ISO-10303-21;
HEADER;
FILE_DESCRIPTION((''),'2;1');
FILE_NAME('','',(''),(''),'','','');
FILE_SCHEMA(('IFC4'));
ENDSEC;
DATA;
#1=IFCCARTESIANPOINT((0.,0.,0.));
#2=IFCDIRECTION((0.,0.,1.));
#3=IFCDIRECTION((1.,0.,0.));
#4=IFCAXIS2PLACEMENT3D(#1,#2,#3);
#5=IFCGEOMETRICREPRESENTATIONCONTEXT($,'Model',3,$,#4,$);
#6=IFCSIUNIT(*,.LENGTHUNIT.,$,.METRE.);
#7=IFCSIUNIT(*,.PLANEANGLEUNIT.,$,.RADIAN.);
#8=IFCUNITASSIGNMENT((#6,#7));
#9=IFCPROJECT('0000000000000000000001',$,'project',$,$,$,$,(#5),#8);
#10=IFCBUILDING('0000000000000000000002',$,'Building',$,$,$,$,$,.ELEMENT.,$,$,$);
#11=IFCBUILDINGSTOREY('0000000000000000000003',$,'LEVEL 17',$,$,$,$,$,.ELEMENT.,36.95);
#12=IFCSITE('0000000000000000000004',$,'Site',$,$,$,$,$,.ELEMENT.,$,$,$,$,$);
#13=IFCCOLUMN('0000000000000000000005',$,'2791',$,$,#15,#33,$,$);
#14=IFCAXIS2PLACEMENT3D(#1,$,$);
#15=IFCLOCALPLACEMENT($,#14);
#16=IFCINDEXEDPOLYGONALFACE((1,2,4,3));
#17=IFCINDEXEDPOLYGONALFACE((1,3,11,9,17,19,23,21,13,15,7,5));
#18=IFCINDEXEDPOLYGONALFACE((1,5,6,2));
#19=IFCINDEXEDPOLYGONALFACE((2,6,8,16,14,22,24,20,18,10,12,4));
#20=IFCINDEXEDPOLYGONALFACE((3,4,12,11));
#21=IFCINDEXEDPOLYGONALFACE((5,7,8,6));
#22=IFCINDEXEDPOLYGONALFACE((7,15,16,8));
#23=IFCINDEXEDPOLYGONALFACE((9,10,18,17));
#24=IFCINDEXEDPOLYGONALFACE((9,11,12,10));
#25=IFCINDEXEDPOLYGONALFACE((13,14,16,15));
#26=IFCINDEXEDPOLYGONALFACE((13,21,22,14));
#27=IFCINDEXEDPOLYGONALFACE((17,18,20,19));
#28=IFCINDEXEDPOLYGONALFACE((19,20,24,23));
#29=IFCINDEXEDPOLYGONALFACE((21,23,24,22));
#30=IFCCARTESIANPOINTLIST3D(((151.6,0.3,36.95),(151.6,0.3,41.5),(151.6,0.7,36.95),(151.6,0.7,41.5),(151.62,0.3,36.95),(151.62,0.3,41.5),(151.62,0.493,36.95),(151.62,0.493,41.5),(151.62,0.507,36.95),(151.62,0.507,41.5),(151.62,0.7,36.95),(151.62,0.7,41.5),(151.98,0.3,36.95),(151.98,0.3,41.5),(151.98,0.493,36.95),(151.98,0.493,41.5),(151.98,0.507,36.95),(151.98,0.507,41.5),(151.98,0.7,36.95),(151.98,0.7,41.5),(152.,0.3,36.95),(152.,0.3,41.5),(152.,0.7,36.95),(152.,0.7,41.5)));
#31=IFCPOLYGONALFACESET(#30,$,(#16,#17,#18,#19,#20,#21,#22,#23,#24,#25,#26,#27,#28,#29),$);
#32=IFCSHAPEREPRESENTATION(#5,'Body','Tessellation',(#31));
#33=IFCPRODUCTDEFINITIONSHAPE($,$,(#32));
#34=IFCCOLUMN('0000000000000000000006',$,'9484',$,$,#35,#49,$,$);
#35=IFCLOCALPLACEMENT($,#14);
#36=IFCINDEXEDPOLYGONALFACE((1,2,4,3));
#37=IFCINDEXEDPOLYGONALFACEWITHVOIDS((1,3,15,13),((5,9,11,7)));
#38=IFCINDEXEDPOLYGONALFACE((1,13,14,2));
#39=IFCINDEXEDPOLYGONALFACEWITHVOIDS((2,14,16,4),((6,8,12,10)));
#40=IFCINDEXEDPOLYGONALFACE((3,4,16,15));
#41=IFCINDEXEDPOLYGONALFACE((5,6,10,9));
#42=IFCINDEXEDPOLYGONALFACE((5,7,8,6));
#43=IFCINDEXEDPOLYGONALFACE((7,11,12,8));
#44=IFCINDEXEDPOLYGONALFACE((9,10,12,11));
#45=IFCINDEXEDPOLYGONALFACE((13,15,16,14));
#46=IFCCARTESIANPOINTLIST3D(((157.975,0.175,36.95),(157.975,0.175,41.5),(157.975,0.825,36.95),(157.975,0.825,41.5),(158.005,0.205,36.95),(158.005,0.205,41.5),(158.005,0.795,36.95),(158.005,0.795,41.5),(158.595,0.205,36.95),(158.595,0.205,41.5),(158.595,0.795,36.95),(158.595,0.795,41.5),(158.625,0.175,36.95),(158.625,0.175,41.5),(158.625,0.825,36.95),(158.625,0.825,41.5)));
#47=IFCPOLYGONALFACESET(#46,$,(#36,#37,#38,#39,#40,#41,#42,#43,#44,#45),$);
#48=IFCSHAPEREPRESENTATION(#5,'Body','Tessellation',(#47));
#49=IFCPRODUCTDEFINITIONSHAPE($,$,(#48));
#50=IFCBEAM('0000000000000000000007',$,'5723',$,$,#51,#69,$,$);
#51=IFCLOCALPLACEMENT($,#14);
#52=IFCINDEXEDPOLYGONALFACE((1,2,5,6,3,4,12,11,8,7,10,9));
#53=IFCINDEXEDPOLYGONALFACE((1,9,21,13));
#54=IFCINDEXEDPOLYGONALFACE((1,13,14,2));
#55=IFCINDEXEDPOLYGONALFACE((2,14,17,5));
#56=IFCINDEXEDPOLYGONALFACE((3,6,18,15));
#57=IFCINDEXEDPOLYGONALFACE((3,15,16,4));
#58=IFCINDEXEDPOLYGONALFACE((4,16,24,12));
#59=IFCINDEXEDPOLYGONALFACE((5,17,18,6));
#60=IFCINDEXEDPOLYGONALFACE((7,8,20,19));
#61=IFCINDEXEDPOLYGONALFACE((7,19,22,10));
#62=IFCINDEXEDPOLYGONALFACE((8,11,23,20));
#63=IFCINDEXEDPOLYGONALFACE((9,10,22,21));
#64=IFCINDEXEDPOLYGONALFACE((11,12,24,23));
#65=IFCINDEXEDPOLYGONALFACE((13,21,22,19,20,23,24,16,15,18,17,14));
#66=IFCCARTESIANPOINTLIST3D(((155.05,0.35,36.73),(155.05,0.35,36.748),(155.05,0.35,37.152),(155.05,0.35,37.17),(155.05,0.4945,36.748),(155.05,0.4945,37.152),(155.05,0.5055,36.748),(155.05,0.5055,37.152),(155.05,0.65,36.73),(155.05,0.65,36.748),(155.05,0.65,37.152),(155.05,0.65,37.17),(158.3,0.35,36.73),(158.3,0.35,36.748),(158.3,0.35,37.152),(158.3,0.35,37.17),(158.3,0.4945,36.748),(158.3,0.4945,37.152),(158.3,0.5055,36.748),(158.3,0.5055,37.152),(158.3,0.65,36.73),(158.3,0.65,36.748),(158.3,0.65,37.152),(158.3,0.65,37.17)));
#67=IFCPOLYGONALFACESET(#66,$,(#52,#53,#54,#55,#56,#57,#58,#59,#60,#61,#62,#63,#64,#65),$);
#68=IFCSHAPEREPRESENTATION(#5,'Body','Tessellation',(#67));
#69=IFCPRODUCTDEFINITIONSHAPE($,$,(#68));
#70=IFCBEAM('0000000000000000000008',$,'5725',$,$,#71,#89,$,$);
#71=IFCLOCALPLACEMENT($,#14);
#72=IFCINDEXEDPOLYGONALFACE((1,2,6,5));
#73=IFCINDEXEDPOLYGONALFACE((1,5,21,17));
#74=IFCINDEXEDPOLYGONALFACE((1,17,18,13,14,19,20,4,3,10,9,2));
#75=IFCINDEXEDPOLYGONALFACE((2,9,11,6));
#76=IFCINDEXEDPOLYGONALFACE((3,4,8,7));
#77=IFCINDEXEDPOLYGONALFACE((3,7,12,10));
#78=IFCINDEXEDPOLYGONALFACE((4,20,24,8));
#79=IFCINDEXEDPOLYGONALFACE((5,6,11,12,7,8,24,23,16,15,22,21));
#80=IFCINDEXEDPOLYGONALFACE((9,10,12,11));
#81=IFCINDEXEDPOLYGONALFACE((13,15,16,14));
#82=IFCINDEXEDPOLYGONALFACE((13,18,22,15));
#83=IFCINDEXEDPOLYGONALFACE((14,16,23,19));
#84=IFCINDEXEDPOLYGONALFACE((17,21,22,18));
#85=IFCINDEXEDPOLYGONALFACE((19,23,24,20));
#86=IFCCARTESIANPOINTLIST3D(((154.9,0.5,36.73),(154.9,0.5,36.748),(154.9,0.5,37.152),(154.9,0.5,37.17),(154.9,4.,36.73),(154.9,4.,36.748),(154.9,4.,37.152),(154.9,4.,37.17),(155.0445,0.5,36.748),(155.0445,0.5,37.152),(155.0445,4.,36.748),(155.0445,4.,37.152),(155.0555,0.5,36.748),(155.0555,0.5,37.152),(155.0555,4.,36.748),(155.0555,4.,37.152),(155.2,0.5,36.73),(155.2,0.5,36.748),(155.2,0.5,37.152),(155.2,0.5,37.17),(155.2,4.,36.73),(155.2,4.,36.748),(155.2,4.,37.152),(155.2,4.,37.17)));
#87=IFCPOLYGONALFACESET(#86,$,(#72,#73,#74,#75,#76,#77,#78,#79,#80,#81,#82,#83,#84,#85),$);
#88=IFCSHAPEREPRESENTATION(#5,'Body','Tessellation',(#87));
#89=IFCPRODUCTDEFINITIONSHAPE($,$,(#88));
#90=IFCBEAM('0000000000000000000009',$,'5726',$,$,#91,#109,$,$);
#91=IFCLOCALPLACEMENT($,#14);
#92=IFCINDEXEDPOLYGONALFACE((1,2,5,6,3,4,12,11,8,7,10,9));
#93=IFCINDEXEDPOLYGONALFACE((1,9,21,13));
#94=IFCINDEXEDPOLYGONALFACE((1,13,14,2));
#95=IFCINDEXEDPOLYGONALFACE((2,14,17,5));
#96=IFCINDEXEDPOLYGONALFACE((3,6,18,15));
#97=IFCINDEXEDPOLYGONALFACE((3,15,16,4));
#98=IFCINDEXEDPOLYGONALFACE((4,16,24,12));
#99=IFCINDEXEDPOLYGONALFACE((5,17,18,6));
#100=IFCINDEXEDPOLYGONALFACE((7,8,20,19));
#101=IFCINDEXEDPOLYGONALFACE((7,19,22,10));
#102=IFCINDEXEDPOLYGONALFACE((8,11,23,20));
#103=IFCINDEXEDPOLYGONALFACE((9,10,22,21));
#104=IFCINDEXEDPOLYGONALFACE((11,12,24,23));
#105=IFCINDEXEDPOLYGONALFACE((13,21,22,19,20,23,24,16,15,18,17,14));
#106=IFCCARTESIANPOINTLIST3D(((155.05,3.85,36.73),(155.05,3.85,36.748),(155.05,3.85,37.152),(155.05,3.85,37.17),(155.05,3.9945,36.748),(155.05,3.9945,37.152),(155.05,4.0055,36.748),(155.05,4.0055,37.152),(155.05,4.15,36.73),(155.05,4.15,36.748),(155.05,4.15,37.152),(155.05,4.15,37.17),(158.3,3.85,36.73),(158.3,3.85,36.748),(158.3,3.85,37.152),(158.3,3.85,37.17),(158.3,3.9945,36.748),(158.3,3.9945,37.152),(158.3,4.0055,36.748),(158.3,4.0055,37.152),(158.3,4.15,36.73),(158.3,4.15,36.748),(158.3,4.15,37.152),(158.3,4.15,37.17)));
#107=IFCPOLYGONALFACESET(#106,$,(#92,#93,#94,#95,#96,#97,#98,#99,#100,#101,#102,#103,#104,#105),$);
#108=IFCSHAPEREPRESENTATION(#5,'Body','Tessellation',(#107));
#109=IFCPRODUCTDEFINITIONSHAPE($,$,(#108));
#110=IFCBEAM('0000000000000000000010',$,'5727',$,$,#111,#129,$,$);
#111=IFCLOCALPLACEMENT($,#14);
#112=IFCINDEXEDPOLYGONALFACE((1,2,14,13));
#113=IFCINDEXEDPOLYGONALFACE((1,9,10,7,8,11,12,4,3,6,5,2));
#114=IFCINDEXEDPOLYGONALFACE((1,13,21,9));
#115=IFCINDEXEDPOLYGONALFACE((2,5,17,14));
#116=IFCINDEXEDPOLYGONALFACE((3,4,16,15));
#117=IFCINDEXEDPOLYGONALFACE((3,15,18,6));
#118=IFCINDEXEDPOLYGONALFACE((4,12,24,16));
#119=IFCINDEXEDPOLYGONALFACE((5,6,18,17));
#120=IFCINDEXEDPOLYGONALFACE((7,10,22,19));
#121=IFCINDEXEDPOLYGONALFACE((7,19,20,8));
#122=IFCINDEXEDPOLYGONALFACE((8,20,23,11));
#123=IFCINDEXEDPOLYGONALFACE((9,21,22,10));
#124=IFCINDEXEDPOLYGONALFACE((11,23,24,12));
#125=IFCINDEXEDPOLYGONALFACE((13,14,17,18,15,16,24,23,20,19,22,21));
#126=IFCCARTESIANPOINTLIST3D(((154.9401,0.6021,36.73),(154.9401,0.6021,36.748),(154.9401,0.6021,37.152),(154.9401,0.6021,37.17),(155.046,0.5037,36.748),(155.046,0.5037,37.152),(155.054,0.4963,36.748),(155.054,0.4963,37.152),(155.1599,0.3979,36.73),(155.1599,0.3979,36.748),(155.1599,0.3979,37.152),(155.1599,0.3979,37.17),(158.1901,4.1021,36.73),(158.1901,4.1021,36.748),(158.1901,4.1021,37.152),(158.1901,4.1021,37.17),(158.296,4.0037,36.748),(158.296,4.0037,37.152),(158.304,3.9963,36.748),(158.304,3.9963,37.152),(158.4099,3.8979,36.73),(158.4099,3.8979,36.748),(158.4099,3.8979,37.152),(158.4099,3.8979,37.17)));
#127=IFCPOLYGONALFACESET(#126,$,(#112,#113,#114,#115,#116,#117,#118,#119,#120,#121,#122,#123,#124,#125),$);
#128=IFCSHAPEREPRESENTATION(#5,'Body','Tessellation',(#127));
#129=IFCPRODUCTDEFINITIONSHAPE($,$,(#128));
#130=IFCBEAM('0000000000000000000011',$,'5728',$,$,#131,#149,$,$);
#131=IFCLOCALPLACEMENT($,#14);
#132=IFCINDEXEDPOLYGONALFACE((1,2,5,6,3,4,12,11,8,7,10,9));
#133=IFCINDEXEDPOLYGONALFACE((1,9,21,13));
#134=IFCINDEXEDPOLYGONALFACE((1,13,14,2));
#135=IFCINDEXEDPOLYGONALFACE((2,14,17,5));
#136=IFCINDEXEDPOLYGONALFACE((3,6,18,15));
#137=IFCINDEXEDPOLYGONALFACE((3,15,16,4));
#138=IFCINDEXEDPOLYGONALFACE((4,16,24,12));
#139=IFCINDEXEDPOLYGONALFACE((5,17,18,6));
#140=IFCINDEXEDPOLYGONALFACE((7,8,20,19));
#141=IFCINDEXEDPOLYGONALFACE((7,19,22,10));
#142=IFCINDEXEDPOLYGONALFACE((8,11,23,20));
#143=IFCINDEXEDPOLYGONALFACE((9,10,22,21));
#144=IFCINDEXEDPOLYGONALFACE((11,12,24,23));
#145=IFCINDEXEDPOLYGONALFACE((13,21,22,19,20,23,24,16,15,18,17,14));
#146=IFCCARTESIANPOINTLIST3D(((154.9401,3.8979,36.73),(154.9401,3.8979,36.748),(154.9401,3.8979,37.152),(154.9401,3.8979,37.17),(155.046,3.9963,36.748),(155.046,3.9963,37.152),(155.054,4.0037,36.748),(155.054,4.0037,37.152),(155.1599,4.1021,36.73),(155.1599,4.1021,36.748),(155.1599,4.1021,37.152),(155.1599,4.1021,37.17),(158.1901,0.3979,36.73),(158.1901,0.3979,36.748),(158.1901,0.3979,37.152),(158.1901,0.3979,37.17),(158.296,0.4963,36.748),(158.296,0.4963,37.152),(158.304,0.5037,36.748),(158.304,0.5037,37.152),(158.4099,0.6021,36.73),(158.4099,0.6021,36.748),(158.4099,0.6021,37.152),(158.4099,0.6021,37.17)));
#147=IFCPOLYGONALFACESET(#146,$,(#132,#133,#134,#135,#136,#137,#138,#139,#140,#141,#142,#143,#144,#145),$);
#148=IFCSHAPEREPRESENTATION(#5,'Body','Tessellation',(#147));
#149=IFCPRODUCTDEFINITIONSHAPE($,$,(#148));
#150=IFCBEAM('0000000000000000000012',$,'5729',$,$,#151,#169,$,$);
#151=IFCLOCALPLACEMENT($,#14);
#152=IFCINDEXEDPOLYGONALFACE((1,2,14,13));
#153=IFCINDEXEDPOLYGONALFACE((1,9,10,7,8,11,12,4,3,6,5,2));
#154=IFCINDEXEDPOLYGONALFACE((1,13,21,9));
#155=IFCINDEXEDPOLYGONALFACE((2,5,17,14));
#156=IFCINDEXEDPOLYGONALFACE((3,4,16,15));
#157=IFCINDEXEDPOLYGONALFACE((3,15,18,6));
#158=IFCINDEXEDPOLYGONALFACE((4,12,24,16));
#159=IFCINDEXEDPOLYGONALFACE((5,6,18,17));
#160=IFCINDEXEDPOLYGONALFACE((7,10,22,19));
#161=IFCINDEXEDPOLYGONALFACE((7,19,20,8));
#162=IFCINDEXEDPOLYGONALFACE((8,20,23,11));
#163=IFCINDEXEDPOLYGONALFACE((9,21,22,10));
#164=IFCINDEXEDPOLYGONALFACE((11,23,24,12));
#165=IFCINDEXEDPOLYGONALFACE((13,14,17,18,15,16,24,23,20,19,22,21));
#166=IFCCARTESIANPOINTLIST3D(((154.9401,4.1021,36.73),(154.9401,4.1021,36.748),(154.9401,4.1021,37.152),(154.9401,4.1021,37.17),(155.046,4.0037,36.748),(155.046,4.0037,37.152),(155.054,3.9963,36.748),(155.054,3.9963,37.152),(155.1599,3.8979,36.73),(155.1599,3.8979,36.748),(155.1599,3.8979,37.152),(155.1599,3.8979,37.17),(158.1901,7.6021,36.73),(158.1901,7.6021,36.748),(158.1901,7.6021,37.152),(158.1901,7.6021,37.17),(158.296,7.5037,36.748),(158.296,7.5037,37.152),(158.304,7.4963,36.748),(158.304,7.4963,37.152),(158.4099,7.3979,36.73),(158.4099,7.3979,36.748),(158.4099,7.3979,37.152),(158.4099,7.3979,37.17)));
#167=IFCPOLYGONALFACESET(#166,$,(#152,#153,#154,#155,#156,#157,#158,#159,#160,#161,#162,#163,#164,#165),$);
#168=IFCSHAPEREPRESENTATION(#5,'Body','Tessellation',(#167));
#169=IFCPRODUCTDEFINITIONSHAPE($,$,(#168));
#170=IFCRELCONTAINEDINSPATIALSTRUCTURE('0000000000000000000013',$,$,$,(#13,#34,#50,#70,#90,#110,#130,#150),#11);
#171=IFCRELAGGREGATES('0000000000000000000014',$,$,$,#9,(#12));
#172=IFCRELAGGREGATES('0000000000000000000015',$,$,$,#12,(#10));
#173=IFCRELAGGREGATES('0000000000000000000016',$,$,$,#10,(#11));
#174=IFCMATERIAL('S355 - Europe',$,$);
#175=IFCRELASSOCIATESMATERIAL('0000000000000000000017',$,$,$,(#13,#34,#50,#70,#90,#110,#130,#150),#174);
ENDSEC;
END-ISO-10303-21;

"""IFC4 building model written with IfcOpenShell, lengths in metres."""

from ifc_helpers import new_model, si_unit, frame, origin_with_axes, origin_2d_with_axis, place, context, project, spatial, hollow_rectangle, i_section, extrude, material, material_profile, profile_set, profile_usage, element, save


model = new_model("IFC4")

# Units and contexts
model_context = context("Model", 3, world=origin_with_axes())
ifc_project = project(units=[si_unit("LENGTHUNIT", "METRE"), si_unit("PLANEANGLEUNIT", "RADIAN")], contexts=[model_context])

# Site, building, storey
site = spatial("IfcSite", under=ifc_project, Name="Site", CompositionType="ELEMENT")
building = spatial("IfcBuilding", under=site, Name="Building", CompositionType="ELEMENT")
storey = spatial("IfcBuildingStorey", under=building, Name="LEVEL 17", CompositionType="ELEMENT", Elevation=36.95)

# Columns
ifc_material = material(Name="S355 - Europe")
ifc_material_profile_1 = material_profile(ifc_material, i_section(OverallWidth=0.4, OverallDepth=0.4, WebThickness=0.014, FlangeThickness=0.02, at=origin_2d_with_axis()))
ifc_profile_set_1 = profile_set([ifc_material_profile_1])
ifc_profile_usage_1 = profile_usage(ifc_profile_set_1, cardinal=10)
column_1_placement = place(None, frame((151.8, 0.5, 36.95), z_axis=(0.0, 0.0, 1.0), x_axis=(0.0, -1.0, 0.0)))
element("IfcColumn", 1, at=column_1_placement, inside=storey, material=ifc_profile_usage_1, Name="2791", context=model_context, shape_type="SweptSolid", body=[
    extrude(i_section(OverallWidth=0.4, OverallDepth=0.4, WebThickness=0.014, FlangeThickness=0.02, at=origin_2d_with_axis()), origin_with_axes(), (0.0, 0.0, 1.0), 4.55),
])
ifc_material_profile_2 = material_profile(ifc_material, hollow_rectangle(XDim=0.65, YDim=0.65, WallThickness=0.03, at=origin_2d_with_axis()))
ifc_profile_set_2 = profile_set([ifc_material_profile_2])
ifc_profile_usage_2 = profile_usage(ifc_profile_set_2, cardinal=10)
column_2_placement = place(None, frame((158.3, 0.5, 36.95), z_axis=(0.0, 0.0, 1.0), x_axis=(0.0, -1.0, 0.0)))
element("IfcColumn", 2, at=column_2_placement, inside=storey, material=ifc_profile_usage_2, Name="9484", context=model_context, shape_type="SweptSolid", body=[
    extrude(hollow_rectangle(XDim=0.65, YDim=0.65, WallThickness=0.03, at=origin_2d_with_axis()), origin_with_axes(), (0.0, 0.0, 1.0), 4.55),
])

# Beams
ifc_material_profile_3 = material_profile(ifc_material, i_section(OverallWidth=0.3, OverallDepth=0.44, WebThickness=0.011, FlangeThickness=0.018, at=origin_2d_with_axis()))
ifc_profile_set_3 = profile_set([ifc_material_profile_3])
ifc_profile_usage_3 = profile_usage(ifc_profile_set_3, cardinal=10)
beam_1_placement = place(None, frame((155.05, 0.5, 36.95), z_axis=(1.0, 0.0, 0.0), x_axis=(0.0, 1.0, 0.0)))
element("IfcBeam", 3, at=beam_1_placement, inside=storey, material=ifc_profile_usage_3, Name="5723", context=model_context, shape_type="SweptSolid", body=[
    extrude(i_section(OverallWidth=0.3, OverallDepth=0.44, WebThickness=0.011, FlangeThickness=0.018, at=origin_2d_with_axis()), origin_with_axes(), (0.0, 0.0, 1.0), 3.25),
])
ifc_material_profile_4 = material_profile(ifc_material, i_section(OverallWidth=0.3, OverallDepth=0.44, WebThickness=0.011, FlangeThickness=0.018, at=origin_2d_with_axis()))
ifc_profile_set_4 = profile_set([ifc_material_profile_4])
ifc_profile_usage_4 = profile_usage(ifc_profile_set_4, cardinal=10)
beam_2_placement = place(None, frame((155.05, 4.0, 36.95), z_axis=(0.0, -1.0, 0.0), x_axis=(1.0, 0.0, 0.0)))
element("IfcBeam", 4, at=beam_2_placement, inside=storey, material=ifc_profile_usage_4, Name="5725", context=model_context, shape_type="SweptSolid", body=[
    extrude(i_section(OverallWidth=0.3, OverallDepth=0.44, WebThickness=0.011, FlangeThickness=0.018, at=origin_2d_with_axis()), origin_with_axes(), (0.0, 0.0, 1.0), 3.5),
])
ifc_material_profile_5 = material_profile(ifc_material, i_section(OverallWidth=0.3, OverallDepth=0.44, WebThickness=0.011, FlangeThickness=0.018, at=origin_2d_with_axis()))
ifc_profile_set_5 = profile_set([ifc_material_profile_5])
ifc_profile_usage_5 = profile_usage(ifc_profile_set_5, cardinal=10)
beam_3_placement = place(None, frame((155.05, 4.0, 36.95), z_axis=(1.0, 0.0, 0.0), x_axis=(0.0, 1.0, 0.0)))
element("IfcBeam", 5, at=beam_3_placement, inside=storey, material=ifc_profile_usage_5, Name="5726", context=model_context, shape_type="SweptSolid", body=[
    extrude(i_section(OverallWidth=0.3, OverallDepth=0.44, WebThickness=0.011, FlangeThickness=0.018, at=origin_2d_with_axis()), origin_with_axes(), (0.0, 0.0, 1.0), 3.25),
])
ifc_material_profile_6 = material_profile(ifc_material, i_section(OverallWidth=0.3, OverallDepth=0.44, WebThickness=0.011, FlangeThickness=0.018, at=origin_2d_with_axis()))
ifc_profile_set_6 = profile_set([ifc_material_profile_6])
ifc_profile_usage_6 = profile_usage(ifc_profile_set_6, cardinal=10)
beam_4_placement = place(None, frame((158.3, 4.0, 36.95), z_axis=(-0.680451, -0.732793, 0.0), x_axis=(0.732793, -0.680451, 0.0)))
element("IfcBeam", 6, at=beam_4_placement, inside=storey, material=ifc_profile_usage_6, Name="5727", context=model_context, shape_type="SweptSolid", body=[
    extrude(i_section(OverallWidth=0.3, OverallDepth=0.44, WebThickness=0.011, FlangeThickness=0.018, at=origin_2d_with_axis()), origin_with_axes(), (0.0, 0.0, 1.0), 4.7762),
])
ifc_material_profile_7 = material_profile(ifc_material, i_section(OverallWidth=0.3, OverallDepth=0.44, WebThickness=0.011, FlangeThickness=0.018, at=origin_2d_with_axis()))
ifc_profile_set_7 = profile_set([ifc_material_profile_7])
ifc_profile_usage_7 = profile_usage(ifc_profile_set_7, cardinal=10)
beam_5_placement = place(None, frame((155.05, 4.0, 36.95), z_axis=(0.680451, -0.732793, 0.0), x_axis=(0.732793, 0.680451, 0.0)))
element("IfcBeam", 7, at=beam_5_placement, inside=storey, material=ifc_profile_usage_7, Name="5728", context=model_context, shape_type="SweptSolid", body=[
    extrude(i_section(OverallWidth=0.3, OverallDepth=0.44, WebThickness=0.011, FlangeThickness=0.018, at=origin_2d_with_axis()), origin_with_axes(), (0.0, 0.0, 1.0), 4.7762),
])
ifc_material_profile_8 = material_profile(ifc_material, i_section(OverallWidth=0.3, OverallDepth=0.44, WebThickness=0.011, FlangeThickness=0.018, at=origin_2d_with_axis()))
ifc_profile_set_8 = profile_set([ifc_material_profile_8])
ifc_profile_usage_8 = profile_usage(ifc_profile_set_8, cardinal=10)
beam_6_placement = place(None, frame((155.05, 4.0, 36.95), z_axis=(0.680451, 0.732793, 0.0), x_axis=(-0.732793, 0.680451, 0.0)))
element("IfcBeam", 8, at=beam_6_placement, inside=storey, material=ifc_profile_usage_8, Name="5729", context=model_context, shape_type="SweptSolid", body=[
    extrude(i_section(OverallWidth=0.3, OverallDepth=0.44, WebThickness=0.011, FlangeThickness=0.018, at=origin_2d_with_axis()), origin_with_axes(), (0.0, 0.0, 1.0), 4.7762),
])

save(model, "model.ifc")
